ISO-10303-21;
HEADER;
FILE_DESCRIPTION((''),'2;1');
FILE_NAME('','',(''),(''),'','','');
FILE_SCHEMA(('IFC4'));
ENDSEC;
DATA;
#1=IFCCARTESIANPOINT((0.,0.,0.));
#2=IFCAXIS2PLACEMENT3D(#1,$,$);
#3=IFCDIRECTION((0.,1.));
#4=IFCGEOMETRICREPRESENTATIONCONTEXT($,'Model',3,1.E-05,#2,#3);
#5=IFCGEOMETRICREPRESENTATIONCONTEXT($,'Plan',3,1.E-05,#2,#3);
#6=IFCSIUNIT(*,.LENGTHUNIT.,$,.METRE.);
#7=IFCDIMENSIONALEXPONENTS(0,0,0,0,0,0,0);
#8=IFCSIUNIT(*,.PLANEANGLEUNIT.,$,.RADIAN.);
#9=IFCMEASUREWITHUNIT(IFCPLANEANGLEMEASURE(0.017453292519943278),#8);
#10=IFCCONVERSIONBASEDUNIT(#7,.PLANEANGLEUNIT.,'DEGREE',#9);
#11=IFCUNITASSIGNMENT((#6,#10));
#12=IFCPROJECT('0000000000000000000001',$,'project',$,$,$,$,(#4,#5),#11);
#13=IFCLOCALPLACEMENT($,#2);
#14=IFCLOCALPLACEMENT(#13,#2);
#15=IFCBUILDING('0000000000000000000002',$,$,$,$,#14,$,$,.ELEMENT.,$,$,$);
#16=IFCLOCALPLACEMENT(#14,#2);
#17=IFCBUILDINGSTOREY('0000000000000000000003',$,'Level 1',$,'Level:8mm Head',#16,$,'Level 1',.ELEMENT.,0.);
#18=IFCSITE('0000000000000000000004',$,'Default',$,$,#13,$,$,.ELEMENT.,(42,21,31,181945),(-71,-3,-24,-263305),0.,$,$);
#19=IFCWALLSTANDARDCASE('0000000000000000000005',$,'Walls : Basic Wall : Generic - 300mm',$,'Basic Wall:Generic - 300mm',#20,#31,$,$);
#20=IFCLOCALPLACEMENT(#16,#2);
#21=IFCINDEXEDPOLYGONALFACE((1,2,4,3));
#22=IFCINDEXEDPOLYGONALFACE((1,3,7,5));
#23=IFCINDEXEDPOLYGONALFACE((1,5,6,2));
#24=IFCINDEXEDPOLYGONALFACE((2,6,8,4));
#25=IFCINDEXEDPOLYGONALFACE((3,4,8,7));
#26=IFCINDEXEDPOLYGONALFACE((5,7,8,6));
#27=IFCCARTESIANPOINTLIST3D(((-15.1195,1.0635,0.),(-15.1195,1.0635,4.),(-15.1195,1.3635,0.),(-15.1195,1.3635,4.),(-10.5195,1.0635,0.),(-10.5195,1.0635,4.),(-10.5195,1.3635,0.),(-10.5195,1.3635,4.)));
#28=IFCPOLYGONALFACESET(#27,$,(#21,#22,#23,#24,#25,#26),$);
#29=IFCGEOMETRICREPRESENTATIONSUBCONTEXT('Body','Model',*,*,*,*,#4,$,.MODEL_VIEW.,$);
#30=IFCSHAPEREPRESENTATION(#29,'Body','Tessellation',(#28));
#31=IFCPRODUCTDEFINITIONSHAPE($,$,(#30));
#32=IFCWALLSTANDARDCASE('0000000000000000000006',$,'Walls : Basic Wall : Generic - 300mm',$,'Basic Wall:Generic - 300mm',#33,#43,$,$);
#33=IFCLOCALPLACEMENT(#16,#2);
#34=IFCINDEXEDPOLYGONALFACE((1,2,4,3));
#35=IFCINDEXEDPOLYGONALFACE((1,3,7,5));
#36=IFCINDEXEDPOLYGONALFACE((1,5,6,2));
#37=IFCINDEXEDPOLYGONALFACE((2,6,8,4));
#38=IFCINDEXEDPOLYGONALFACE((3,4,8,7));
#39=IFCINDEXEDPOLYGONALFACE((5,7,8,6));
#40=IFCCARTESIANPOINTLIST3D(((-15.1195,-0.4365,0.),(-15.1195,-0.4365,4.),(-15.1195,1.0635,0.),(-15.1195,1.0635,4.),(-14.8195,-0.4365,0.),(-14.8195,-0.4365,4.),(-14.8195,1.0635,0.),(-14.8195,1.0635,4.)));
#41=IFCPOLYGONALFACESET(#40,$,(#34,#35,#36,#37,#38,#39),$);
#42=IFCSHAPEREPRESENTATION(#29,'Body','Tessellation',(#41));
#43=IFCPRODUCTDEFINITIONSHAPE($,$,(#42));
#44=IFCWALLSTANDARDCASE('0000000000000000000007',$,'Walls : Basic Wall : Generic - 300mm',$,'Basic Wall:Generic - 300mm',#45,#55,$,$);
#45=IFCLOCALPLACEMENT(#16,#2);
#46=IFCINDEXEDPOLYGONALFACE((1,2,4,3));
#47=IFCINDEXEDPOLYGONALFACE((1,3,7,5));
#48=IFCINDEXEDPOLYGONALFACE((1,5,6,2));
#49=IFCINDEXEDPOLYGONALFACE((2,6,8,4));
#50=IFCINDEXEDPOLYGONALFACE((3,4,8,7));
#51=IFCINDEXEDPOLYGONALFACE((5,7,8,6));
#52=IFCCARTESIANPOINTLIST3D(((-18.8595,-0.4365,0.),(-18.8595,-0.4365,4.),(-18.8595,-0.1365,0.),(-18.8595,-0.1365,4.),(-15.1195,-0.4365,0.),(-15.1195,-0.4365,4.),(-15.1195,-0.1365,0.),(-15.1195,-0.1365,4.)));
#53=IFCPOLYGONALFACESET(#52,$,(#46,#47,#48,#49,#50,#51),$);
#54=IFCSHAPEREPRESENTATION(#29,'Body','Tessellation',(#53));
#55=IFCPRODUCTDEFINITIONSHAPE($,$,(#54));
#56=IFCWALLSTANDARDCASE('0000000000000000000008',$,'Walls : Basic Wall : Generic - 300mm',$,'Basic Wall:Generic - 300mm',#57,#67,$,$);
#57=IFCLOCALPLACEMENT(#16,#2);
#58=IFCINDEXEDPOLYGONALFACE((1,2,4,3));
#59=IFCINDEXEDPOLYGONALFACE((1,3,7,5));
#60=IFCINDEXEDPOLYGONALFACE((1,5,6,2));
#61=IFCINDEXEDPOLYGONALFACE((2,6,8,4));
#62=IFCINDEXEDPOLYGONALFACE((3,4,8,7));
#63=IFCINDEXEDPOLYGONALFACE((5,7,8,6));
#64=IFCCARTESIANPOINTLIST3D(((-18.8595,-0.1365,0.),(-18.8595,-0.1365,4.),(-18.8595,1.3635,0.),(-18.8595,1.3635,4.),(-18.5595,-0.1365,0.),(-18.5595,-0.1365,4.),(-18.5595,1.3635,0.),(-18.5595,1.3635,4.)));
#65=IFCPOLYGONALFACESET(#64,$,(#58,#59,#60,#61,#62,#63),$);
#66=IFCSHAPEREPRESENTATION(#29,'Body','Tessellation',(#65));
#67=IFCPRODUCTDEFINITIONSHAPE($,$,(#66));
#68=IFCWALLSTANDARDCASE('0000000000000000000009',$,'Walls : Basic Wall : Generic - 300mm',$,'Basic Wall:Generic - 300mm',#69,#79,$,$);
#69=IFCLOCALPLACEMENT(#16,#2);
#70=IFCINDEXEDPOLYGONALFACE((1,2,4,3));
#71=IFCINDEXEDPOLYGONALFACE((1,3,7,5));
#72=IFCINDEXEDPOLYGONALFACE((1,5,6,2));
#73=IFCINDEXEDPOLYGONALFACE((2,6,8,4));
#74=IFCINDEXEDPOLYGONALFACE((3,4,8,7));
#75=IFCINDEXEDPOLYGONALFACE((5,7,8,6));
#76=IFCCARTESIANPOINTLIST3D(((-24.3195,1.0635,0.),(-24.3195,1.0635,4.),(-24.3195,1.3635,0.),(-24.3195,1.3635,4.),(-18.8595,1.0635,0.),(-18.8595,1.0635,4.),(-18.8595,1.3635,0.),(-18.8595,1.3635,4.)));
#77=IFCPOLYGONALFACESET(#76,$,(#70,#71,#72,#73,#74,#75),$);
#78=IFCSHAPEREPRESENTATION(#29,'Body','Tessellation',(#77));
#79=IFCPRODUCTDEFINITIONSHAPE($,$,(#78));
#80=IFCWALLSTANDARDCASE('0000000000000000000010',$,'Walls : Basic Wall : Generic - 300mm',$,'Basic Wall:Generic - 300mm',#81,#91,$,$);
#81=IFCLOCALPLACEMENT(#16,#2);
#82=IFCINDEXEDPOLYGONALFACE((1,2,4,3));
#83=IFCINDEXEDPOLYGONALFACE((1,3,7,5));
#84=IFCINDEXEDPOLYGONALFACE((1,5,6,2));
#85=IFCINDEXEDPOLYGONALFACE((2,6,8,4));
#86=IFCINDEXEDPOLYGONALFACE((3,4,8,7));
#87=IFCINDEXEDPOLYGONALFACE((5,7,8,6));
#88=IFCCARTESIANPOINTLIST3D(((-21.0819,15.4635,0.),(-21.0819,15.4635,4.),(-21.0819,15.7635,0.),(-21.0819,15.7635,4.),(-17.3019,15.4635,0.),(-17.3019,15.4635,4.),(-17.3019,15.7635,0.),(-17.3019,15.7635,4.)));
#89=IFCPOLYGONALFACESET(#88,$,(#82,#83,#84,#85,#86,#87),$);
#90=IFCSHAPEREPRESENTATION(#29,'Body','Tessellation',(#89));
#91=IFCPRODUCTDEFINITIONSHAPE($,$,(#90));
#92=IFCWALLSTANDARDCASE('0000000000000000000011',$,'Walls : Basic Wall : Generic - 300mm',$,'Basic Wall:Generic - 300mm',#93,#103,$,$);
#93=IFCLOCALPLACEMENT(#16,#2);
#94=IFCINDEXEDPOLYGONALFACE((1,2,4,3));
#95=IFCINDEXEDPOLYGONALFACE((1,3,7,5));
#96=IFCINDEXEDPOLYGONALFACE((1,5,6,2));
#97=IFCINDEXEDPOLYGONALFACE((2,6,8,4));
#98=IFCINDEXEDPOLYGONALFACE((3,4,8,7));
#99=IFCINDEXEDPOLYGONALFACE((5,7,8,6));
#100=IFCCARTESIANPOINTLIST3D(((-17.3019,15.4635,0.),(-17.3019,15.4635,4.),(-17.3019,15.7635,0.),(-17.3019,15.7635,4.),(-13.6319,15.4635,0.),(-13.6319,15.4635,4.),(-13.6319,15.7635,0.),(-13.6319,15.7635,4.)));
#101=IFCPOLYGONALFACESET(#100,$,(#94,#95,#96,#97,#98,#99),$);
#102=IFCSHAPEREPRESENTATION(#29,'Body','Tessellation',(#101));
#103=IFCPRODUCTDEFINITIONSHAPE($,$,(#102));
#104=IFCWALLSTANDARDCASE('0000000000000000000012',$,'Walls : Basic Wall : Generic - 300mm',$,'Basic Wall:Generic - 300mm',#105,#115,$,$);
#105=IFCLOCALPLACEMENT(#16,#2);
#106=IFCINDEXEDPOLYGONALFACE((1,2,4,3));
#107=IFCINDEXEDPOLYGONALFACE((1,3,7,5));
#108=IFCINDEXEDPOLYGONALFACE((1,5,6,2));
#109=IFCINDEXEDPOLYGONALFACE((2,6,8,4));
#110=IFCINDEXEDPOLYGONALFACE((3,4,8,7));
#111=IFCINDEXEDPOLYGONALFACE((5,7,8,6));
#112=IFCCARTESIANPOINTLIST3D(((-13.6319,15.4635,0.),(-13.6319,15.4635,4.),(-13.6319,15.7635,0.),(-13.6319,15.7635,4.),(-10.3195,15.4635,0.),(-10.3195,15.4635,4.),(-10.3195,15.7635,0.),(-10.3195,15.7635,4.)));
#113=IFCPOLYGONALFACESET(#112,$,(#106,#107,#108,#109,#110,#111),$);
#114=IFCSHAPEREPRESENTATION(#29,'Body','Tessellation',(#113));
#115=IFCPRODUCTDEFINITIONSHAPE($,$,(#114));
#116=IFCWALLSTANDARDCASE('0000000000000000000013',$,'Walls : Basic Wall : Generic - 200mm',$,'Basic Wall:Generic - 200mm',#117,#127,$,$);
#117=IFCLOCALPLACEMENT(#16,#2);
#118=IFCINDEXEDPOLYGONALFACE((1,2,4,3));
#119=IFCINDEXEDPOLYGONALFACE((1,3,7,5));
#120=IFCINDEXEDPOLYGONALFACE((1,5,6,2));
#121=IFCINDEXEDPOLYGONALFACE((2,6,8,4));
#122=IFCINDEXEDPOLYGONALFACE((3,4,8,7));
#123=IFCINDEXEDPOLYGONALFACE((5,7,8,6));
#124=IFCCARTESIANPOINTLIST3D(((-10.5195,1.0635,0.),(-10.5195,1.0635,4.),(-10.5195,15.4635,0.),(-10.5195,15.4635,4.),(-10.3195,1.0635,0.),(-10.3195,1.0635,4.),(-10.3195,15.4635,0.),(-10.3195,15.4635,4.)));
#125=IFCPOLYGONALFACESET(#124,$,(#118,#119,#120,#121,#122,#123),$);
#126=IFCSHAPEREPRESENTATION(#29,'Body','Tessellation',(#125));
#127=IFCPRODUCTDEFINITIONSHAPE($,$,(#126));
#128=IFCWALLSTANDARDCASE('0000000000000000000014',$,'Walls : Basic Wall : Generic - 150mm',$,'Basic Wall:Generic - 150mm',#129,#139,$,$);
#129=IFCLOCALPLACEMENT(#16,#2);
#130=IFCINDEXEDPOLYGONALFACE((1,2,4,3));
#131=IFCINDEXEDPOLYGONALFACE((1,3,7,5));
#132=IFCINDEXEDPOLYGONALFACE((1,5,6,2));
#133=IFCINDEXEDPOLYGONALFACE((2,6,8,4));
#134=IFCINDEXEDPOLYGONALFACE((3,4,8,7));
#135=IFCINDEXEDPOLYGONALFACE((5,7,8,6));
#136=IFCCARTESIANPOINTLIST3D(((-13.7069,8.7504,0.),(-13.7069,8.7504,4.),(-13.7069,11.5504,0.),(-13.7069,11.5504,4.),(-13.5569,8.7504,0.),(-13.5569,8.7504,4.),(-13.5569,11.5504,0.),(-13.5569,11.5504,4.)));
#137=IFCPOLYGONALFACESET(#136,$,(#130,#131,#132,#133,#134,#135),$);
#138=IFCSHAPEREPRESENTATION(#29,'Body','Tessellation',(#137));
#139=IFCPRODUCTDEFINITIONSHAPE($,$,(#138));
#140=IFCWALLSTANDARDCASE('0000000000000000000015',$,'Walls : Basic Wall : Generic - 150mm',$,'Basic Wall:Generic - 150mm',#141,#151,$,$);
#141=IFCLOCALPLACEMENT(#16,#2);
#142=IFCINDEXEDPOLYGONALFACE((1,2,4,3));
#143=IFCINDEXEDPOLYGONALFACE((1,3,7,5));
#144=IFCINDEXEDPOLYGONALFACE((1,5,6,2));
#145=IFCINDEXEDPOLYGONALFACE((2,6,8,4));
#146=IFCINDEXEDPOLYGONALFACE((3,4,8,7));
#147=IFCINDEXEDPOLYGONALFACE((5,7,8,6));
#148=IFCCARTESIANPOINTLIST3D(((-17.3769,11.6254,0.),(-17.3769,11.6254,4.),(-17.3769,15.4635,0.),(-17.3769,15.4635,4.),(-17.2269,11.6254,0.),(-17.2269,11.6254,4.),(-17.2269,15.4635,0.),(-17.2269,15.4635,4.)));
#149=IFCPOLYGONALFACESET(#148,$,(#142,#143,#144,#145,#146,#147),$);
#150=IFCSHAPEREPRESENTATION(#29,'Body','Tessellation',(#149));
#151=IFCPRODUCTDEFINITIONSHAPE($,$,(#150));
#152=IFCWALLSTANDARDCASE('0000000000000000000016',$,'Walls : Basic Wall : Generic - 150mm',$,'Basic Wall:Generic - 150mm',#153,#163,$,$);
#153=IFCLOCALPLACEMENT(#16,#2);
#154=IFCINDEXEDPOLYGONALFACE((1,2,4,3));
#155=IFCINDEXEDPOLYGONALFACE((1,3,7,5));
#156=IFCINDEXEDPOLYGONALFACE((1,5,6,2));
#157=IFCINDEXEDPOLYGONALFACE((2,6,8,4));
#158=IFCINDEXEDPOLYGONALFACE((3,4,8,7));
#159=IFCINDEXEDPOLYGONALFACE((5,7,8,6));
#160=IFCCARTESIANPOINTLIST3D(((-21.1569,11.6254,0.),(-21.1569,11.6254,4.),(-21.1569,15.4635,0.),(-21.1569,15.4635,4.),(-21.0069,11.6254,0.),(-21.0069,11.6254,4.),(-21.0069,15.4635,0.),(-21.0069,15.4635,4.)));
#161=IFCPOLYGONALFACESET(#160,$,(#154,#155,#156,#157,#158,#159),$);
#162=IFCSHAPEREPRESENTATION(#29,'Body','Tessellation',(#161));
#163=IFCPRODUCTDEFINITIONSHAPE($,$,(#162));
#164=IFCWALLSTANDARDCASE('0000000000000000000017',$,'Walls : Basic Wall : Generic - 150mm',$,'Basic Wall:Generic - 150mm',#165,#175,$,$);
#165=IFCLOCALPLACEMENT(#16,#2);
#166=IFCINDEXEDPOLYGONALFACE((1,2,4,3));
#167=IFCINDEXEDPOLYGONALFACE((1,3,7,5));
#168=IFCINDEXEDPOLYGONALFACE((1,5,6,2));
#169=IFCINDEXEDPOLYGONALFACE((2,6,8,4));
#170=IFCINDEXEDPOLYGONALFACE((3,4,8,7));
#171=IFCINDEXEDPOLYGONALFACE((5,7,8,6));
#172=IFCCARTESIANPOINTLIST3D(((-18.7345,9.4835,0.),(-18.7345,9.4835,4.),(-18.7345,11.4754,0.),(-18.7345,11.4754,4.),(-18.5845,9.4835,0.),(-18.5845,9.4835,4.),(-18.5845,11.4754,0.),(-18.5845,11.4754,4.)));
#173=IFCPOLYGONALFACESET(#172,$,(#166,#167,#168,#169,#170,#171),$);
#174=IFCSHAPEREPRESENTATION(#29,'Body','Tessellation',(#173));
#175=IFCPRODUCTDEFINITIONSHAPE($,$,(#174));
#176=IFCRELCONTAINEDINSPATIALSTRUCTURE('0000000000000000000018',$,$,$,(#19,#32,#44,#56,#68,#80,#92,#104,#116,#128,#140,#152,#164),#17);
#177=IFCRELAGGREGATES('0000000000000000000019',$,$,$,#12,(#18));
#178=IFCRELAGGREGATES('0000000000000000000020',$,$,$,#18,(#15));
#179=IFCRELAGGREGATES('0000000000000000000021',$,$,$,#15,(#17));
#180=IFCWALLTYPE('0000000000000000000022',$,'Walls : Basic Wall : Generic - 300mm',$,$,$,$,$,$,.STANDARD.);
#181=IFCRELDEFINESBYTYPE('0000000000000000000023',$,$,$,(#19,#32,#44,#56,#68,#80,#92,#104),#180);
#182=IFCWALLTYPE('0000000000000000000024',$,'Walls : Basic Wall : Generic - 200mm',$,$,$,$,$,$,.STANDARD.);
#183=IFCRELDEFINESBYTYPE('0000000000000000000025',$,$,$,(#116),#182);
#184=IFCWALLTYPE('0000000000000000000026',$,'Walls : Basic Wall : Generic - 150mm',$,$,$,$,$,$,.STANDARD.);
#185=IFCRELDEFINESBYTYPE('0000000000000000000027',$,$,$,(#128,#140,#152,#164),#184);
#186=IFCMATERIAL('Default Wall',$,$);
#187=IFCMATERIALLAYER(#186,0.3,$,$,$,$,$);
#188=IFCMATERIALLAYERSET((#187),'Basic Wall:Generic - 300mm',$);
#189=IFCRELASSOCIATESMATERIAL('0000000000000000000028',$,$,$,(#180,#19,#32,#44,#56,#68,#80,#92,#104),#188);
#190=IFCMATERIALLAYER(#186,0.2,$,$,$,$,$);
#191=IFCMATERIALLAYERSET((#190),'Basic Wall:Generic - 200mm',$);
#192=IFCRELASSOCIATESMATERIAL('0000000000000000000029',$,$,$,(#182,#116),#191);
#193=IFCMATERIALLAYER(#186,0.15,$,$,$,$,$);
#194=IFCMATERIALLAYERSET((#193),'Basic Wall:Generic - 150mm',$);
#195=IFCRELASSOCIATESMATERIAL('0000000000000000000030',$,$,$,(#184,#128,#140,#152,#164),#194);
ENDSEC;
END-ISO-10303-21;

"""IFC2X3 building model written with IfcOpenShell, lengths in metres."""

from ifc_helpers import new_model, entity, si_unit, converted_unit, direction, frame, frame_2d, origin, place, context, subcontext, project, spatial, rectangle, extrude, material, layer, layer_set, layer_usage, type_object, element, save


model = new_model("IFC2X3")

# Units and contexts
model_context = context("Model", 3, precision=1e-05, world=origin(), true_north=direction((0.0, 1.0)))
plan_context = context("Plan", 3, precision=1e-05, world=origin(), true_north=direction((0.0, 1.0)))
body_context = subcontext(model_context, "Body", "Model", "MODEL_VIEW")
ifc_project = project(units=[si_unit("LENGTHUNIT", "METRE"), converted_unit("PLANEANGLEUNIT", "DEGREE", entity("IfcPlaneAngleMeasure", 0.017453292519943278), si_unit("PLANEANGLEUNIT", "RADIAN"), dimensions=[0, 0, 0, 0, 0, 0, 0])], contexts=[model_context, plan_context])

# Site, building, storey
site_placement = place(None, origin())
site = spatial("IfcSite", under=ifc_project, at=site_placement, Name="Default", CompositionType="ELEMENT", RefLatitude=(42, 21, 31, 181945), RefLongitude=(-71, -3, -24, -263305), RefElevation=0.0)
building_placement = place(site_placement, origin())
building = spatial("IfcBuilding", under=site, at=building_placement, CompositionType="ELEMENT")
storey_placement = place(building_placement, origin())
storey = spatial("IfcBuildingStorey", under=building, at=storey_placement, Name="Level 1", ObjectType="Level:8mm Head", LongName="Level 1", CompositionType="ELEMENT", Elevation=0.0)

# Walls
ifc_material = material(Name="Default Wall")
ifc_layer_1 = layer(ifc_material, 0.3)
ifc_layer_set_1 = layer_set([ifc_layer_1], Name="Basic Wall:Generic - 300mm")
ifc_layer_usage_1 = layer_usage(ifc_layer_set_1, "AXIS2", "NEGATIVE", 0.15)
wall_type_1 = type_object("IfcWallType", Name="Walls : Basic Wall : Generic - 300mm", PredefinedType="STANDARD", material=ifc_layer_set_1)
wall_1_placement = place(storey_placement, frame((-10.5195, 1.2135, 0.0), z_axis=(0.0, 0.0, 1.0), x_axis=(-1.0, 0.0, 0.0)))
element("IfcWallStandardCase", 1, at=wall_1_placement, inside=storey, type_object=wall_type_1, material=ifc_layer_usage_1, Name="Walls : Basic Wall : Generic - 300mm", ObjectType="Basic Wall:Generic - 300mm", context=body_context, shape_type="SweptSolid", body=[
    extrude(rectangle(XDim=4.6, YDim=0.3, at=frame_2d((2.3, 0.0), x_axis=(-1.0, 0.0))), origin(), (0.0, 0.0, 1.0), 4.0),
])
wall_2_placement = place(storey_placement, frame((-14.9695, 1.0635, 0.0), z_axis=(0.0, 0.0, 1.0), x_axis=(0.0, -1.0, 0.0)))
element("IfcWallStandardCase", 2, at=wall_2_placement, inside=storey, type_object=wall_type_1, material=ifc_layer_usage_1, Name="Walls : Basic Wall : Generic - 300mm", ObjectType="Basic Wall:Generic - 300mm", context=body_context, shape_type="SweptSolid", body=[
    extrude(rectangle(XDim=1.5, YDim=0.3, at=frame_2d((0.75, 0.0), x_axis=(-1.0, 0.0))), origin(), (0.0, 0.0, 1.0), 4.0),
])
wall_3_placement = place(storey_placement, frame((-15.1195, -0.2865, 0.0), z_axis=(0.0, 0.0, 1.0), x_axis=(-1.0, 0.0, 0.0)))
element("IfcWallStandardCase", 3, at=wall_3_placement, inside=storey, type_object=wall_type_1, material=ifc_layer_usage_1, Name="Walls : Basic Wall : Generic - 300mm", ObjectType="Basic Wall:Generic - 300mm", context=body_context, shape_type="SweptSolid", body=[
    extrude(rectangle(XDim=3.74, YDim=0.3, at=frame_2d((1.87, 0.0), x_axis=(-1.0, 0.0))), origin(), (0.0, 0.0, 1.0), 4.0),
])
wall_4_placement = place(storey_placement, frame((-18.7095, -0.1365, 0.0), z_axis=(0.0, 0.0, 1.0), x_axis=(0.0, 1.0, 0.0)))
element("IfcWallStandardCase", 4, at=wall_4_placement, inside=storey, type_object=wall_type_1, material=ifc_layer_usage_1, Name="Walls : Basic Wall : Generic - 300mm", ObjectType="Basic Wall:Generic - 300mm", context=body_context, shape_type="SweptSolid", body=[
    extrude(rectangle(XDim=1.5, YDim=0.3, at=frame_2d((0.75, 0.0), x_axis=(-1.0, 0.0))), origin(), (0.0, 0.0, 1.0), 4.0),
])
wall_5_placement = place(storey_placement, frame((-18.8595, 1.2135, 0.0), z_axis=(0.0, 0.0, 1.0), x_axis=(-1.0, 0.0, 0.0)))
element("IfcWallStandardCase", 5, at=wall_5_placement, inside=storey, type_object=wall_type_1, material=ifc_layer_usage_1, Name="Walls : Basic Wall : Generic - 300mm", ObjectType="Basic Wall:Generic - 300mm", context=body_context, shape_type="SweptSolid", body=[
    extrude(rectangle(XDim=5.46, YDim=0.3, at=frame_2d((2.73, 0.0), x_axis=(-1.0, 0.0))), origin(), (0.0, 0.0, 1.0), 4.0),
])
wall_6_placement = place(storey_placement, frame((-21.0819, 15.6135, 0.0)))
element("IfcWallStandardCase", 6, at=wall_6_placement, inside=storey, type_object=wall_type_1, material=ifc_layer_usage_1, Name="Walls : Basic Wall : Generic - 300mm", ObjectType="Basic Wall:Generic - 300mm", context=body_context, shape_type="SweptSolid", body=[
    extrude(rectangle(XDim=3.78, YDim=0.3, at=frame_2d((1.89, 0.0), x_axis=(-1.0, 0.0))), origin(), (0.0, 0.0, 1.0), 4.0),
])
wall_7_placement = place(storey_placement, frame((-17.3019, 15.6135, 0.0)))
element("IfcWallStandardCase", 7, at=wall_7_placement, inside=storey, type_object=wall_type_1, material=ifc_layer_usage_1, Name="Walls : Basic Wall : Generic - 300mm", ObjectType="Basic Wall:Generic - 300mm", context=body_context, shape_type="SweptSolid", body=[
    extrude(rectangle(XDim=3.67, YDim=0.3, at=frame_2d((1.835, 0.0), x_axis=(-1.0, 0.0))), origin(), (0.0, 0.0, 1.0), 4.0),
])
wall_8_placement = place(storey_placement, frame((-13.6319, 15.6135, 0.0)))
element("IfcWallStandardCase", 8, at=wall_8_placement, inside=storey, type_object=wall_type_1, material=ifc_layer_usage_1, Name="Walls : Basic Wall : Generic - 300mm", ObjectType="Basic Wall:Generic - 300mm", context=body_context, shape_type="SweptSolid", body=[
    extrude(rectangle(XDim=3.3124, YDim=0.3, at=frame_2d((1.6562, 0.0), x_axis=(-1.0, 0.0))), origin(), (0.0, 0.0, 1.0), 4.0),
])
ifc_layer_2 = layer(ifc_material, 0.2)
ifc_layer_set_2 = layer_set([ifc_layer_2], Name="Basic Wall:Generic - 200mm")
ifc_layer_usage_2 = layer_usage(ifc_layer_set_2, "AXIS2", "NEGATIVE", 0.1)
wall_type_2 = type_object("IfcWallType", Name="Walls : Basic Wall : Generic - 200mm", PredefinedType="STANDARD", material=ifc_layer_set_2)
wall_9_placement = place(storey_placement, frame((-10.4195, 15.4635, 0.0), z_axis=(0.0, 0.0, 1.0), x_axis=(0.0, -1.0, 0.0)))
element("IfcWallStandardCase", 9, at=wall_9_placement, inside=storey, type_object=wall_type_2, material=ifc_layer_usage_2, Name="Walls : Basic Wall : Generic - 200mm", ObjectType="Basic Wall:Generic - 200mm", context=body_context, shape_type="SweptSolid", body=[
    extrude(rectangle(XDim=14.4, YDim=0.2, at=frame_2d((7.2, 0.0), x_axis=(-1.0, 0.0))), origin(), (0.0, 0.0, 1.0), 4.0),
])
ifc_layer_3 = layer(ifc_material, 0.15)
ifc_layer_set_3 = layer_set([ifc_layer_3], Name="Basic Wall:Generic - 150mm")
ifc_layer_usage_3 = layer_usage(ifc_layer_set_3, "AXIS2", "NEGATIVE", 0.075)
wall_type_3 = type_object("IfcWallType", Name="Walls : Basic Wall : Generic - 150mm", PredefinedType="STANDARD", material=ifc_layer_set_3)
wall_10_placement = place(storey_placement, frame((-13.6319, 8.7504, 0.0), z_axis=(0.0, 0.0, 1.0), x_axis=(0.0, 1.0, 0.0)))
element("IfcWallStandardCase", 10, at=wall_10_placement, inside=storey, type_object=wall_type_3, material=ifc_layer_usage_3, Name="Walls : Basic Wall : Generic - 150mm", ObjectType="Basic Wall:Generic - 150mm", context=body_context, shape_type="SweptSolid", body=[
    extrude(rectangle(XDim=2.8, YDim=0.15, at=frame_2d((1.4, 0.0), x_axis=(-1.0, 0.0))), origin(), (0.0, 0.0, 1.0), 4.0),
])
wall_11_placement = place(storey_placement, frame((-17.3019, 11.6254, 0.0), z_axis=(0.0, 0.0, 1.0), x_axis=(0.0, 1.0, 0.0)))
element("IfcWallStandardCase", 11, at=wall_11_placement, inside=storey, type_object=wall_type_3, material=ifc_layer_usage_3, Name="Walls : Basic Wall : Generic - 150mm", ObjectType="Basic Wall:Generic - 150mm", context=body_context, shape_type="SweptSolid", body=[
    extrude(rectangle(XDim=3.8381, YDim=0.15, at=frame_2d((1.919, 0.0), x_axis=(-1.0, 0.0))), origin(), (0.0, 0.0, 1.0), 4.0),
])
wall_12_placement = place(storey_placement, frame((-21.0819, 11.6254, 0.0), z_axis=(0.0, 0.0, 1.0), x_axis=(0.0, 1.0, 0.0)))
element("IfcWallStandardCase", 12, at=wall_12_placement, inside=storey, type_object=wall_type_3, material=ifc_layer_usage_3, Name="Walls : Basic Wall : Generic - 150mm", ObjectType="Basic Wall:Generic - 150mm", context=body_context, shape_type="SweptSolid", body=[
    extrude(rectangle(XDim=3.8381, YDim=0.15, at=frame_2d((1.919, 0.0), x_axis=(-1.0, 0.0))), origin(), (0.0, 0.0, 1.0), 4.0),
])
wall_13_placement = place(storey_placement, frame((-18.6595, 11.4754, 0.0), z_axis=(0.0, 0.0, 1.0), x_axis=(0.0, -1.0, 0.0)))
element("IfcWallStandardCase", 13, at=wall_13_placement, inside=storey, type_object=wall_type_3, material=ifc_layer_usage_3, Name="Walls : Basic Wall : Generic - 150mm", ObjectType="Basic Wall:Generic - 150mm", context=body_context, shape_type="SweptSolid", body=[
    extrude(rectangle(XDim=1.9919, YDim=0.15, at=frame_2d((0.996, 0.0), x_axis=(-1.0, 0.0))), origin(), (0.0, 0.0, 1.0), 4.0),
])

save(model, "model.ifc")
